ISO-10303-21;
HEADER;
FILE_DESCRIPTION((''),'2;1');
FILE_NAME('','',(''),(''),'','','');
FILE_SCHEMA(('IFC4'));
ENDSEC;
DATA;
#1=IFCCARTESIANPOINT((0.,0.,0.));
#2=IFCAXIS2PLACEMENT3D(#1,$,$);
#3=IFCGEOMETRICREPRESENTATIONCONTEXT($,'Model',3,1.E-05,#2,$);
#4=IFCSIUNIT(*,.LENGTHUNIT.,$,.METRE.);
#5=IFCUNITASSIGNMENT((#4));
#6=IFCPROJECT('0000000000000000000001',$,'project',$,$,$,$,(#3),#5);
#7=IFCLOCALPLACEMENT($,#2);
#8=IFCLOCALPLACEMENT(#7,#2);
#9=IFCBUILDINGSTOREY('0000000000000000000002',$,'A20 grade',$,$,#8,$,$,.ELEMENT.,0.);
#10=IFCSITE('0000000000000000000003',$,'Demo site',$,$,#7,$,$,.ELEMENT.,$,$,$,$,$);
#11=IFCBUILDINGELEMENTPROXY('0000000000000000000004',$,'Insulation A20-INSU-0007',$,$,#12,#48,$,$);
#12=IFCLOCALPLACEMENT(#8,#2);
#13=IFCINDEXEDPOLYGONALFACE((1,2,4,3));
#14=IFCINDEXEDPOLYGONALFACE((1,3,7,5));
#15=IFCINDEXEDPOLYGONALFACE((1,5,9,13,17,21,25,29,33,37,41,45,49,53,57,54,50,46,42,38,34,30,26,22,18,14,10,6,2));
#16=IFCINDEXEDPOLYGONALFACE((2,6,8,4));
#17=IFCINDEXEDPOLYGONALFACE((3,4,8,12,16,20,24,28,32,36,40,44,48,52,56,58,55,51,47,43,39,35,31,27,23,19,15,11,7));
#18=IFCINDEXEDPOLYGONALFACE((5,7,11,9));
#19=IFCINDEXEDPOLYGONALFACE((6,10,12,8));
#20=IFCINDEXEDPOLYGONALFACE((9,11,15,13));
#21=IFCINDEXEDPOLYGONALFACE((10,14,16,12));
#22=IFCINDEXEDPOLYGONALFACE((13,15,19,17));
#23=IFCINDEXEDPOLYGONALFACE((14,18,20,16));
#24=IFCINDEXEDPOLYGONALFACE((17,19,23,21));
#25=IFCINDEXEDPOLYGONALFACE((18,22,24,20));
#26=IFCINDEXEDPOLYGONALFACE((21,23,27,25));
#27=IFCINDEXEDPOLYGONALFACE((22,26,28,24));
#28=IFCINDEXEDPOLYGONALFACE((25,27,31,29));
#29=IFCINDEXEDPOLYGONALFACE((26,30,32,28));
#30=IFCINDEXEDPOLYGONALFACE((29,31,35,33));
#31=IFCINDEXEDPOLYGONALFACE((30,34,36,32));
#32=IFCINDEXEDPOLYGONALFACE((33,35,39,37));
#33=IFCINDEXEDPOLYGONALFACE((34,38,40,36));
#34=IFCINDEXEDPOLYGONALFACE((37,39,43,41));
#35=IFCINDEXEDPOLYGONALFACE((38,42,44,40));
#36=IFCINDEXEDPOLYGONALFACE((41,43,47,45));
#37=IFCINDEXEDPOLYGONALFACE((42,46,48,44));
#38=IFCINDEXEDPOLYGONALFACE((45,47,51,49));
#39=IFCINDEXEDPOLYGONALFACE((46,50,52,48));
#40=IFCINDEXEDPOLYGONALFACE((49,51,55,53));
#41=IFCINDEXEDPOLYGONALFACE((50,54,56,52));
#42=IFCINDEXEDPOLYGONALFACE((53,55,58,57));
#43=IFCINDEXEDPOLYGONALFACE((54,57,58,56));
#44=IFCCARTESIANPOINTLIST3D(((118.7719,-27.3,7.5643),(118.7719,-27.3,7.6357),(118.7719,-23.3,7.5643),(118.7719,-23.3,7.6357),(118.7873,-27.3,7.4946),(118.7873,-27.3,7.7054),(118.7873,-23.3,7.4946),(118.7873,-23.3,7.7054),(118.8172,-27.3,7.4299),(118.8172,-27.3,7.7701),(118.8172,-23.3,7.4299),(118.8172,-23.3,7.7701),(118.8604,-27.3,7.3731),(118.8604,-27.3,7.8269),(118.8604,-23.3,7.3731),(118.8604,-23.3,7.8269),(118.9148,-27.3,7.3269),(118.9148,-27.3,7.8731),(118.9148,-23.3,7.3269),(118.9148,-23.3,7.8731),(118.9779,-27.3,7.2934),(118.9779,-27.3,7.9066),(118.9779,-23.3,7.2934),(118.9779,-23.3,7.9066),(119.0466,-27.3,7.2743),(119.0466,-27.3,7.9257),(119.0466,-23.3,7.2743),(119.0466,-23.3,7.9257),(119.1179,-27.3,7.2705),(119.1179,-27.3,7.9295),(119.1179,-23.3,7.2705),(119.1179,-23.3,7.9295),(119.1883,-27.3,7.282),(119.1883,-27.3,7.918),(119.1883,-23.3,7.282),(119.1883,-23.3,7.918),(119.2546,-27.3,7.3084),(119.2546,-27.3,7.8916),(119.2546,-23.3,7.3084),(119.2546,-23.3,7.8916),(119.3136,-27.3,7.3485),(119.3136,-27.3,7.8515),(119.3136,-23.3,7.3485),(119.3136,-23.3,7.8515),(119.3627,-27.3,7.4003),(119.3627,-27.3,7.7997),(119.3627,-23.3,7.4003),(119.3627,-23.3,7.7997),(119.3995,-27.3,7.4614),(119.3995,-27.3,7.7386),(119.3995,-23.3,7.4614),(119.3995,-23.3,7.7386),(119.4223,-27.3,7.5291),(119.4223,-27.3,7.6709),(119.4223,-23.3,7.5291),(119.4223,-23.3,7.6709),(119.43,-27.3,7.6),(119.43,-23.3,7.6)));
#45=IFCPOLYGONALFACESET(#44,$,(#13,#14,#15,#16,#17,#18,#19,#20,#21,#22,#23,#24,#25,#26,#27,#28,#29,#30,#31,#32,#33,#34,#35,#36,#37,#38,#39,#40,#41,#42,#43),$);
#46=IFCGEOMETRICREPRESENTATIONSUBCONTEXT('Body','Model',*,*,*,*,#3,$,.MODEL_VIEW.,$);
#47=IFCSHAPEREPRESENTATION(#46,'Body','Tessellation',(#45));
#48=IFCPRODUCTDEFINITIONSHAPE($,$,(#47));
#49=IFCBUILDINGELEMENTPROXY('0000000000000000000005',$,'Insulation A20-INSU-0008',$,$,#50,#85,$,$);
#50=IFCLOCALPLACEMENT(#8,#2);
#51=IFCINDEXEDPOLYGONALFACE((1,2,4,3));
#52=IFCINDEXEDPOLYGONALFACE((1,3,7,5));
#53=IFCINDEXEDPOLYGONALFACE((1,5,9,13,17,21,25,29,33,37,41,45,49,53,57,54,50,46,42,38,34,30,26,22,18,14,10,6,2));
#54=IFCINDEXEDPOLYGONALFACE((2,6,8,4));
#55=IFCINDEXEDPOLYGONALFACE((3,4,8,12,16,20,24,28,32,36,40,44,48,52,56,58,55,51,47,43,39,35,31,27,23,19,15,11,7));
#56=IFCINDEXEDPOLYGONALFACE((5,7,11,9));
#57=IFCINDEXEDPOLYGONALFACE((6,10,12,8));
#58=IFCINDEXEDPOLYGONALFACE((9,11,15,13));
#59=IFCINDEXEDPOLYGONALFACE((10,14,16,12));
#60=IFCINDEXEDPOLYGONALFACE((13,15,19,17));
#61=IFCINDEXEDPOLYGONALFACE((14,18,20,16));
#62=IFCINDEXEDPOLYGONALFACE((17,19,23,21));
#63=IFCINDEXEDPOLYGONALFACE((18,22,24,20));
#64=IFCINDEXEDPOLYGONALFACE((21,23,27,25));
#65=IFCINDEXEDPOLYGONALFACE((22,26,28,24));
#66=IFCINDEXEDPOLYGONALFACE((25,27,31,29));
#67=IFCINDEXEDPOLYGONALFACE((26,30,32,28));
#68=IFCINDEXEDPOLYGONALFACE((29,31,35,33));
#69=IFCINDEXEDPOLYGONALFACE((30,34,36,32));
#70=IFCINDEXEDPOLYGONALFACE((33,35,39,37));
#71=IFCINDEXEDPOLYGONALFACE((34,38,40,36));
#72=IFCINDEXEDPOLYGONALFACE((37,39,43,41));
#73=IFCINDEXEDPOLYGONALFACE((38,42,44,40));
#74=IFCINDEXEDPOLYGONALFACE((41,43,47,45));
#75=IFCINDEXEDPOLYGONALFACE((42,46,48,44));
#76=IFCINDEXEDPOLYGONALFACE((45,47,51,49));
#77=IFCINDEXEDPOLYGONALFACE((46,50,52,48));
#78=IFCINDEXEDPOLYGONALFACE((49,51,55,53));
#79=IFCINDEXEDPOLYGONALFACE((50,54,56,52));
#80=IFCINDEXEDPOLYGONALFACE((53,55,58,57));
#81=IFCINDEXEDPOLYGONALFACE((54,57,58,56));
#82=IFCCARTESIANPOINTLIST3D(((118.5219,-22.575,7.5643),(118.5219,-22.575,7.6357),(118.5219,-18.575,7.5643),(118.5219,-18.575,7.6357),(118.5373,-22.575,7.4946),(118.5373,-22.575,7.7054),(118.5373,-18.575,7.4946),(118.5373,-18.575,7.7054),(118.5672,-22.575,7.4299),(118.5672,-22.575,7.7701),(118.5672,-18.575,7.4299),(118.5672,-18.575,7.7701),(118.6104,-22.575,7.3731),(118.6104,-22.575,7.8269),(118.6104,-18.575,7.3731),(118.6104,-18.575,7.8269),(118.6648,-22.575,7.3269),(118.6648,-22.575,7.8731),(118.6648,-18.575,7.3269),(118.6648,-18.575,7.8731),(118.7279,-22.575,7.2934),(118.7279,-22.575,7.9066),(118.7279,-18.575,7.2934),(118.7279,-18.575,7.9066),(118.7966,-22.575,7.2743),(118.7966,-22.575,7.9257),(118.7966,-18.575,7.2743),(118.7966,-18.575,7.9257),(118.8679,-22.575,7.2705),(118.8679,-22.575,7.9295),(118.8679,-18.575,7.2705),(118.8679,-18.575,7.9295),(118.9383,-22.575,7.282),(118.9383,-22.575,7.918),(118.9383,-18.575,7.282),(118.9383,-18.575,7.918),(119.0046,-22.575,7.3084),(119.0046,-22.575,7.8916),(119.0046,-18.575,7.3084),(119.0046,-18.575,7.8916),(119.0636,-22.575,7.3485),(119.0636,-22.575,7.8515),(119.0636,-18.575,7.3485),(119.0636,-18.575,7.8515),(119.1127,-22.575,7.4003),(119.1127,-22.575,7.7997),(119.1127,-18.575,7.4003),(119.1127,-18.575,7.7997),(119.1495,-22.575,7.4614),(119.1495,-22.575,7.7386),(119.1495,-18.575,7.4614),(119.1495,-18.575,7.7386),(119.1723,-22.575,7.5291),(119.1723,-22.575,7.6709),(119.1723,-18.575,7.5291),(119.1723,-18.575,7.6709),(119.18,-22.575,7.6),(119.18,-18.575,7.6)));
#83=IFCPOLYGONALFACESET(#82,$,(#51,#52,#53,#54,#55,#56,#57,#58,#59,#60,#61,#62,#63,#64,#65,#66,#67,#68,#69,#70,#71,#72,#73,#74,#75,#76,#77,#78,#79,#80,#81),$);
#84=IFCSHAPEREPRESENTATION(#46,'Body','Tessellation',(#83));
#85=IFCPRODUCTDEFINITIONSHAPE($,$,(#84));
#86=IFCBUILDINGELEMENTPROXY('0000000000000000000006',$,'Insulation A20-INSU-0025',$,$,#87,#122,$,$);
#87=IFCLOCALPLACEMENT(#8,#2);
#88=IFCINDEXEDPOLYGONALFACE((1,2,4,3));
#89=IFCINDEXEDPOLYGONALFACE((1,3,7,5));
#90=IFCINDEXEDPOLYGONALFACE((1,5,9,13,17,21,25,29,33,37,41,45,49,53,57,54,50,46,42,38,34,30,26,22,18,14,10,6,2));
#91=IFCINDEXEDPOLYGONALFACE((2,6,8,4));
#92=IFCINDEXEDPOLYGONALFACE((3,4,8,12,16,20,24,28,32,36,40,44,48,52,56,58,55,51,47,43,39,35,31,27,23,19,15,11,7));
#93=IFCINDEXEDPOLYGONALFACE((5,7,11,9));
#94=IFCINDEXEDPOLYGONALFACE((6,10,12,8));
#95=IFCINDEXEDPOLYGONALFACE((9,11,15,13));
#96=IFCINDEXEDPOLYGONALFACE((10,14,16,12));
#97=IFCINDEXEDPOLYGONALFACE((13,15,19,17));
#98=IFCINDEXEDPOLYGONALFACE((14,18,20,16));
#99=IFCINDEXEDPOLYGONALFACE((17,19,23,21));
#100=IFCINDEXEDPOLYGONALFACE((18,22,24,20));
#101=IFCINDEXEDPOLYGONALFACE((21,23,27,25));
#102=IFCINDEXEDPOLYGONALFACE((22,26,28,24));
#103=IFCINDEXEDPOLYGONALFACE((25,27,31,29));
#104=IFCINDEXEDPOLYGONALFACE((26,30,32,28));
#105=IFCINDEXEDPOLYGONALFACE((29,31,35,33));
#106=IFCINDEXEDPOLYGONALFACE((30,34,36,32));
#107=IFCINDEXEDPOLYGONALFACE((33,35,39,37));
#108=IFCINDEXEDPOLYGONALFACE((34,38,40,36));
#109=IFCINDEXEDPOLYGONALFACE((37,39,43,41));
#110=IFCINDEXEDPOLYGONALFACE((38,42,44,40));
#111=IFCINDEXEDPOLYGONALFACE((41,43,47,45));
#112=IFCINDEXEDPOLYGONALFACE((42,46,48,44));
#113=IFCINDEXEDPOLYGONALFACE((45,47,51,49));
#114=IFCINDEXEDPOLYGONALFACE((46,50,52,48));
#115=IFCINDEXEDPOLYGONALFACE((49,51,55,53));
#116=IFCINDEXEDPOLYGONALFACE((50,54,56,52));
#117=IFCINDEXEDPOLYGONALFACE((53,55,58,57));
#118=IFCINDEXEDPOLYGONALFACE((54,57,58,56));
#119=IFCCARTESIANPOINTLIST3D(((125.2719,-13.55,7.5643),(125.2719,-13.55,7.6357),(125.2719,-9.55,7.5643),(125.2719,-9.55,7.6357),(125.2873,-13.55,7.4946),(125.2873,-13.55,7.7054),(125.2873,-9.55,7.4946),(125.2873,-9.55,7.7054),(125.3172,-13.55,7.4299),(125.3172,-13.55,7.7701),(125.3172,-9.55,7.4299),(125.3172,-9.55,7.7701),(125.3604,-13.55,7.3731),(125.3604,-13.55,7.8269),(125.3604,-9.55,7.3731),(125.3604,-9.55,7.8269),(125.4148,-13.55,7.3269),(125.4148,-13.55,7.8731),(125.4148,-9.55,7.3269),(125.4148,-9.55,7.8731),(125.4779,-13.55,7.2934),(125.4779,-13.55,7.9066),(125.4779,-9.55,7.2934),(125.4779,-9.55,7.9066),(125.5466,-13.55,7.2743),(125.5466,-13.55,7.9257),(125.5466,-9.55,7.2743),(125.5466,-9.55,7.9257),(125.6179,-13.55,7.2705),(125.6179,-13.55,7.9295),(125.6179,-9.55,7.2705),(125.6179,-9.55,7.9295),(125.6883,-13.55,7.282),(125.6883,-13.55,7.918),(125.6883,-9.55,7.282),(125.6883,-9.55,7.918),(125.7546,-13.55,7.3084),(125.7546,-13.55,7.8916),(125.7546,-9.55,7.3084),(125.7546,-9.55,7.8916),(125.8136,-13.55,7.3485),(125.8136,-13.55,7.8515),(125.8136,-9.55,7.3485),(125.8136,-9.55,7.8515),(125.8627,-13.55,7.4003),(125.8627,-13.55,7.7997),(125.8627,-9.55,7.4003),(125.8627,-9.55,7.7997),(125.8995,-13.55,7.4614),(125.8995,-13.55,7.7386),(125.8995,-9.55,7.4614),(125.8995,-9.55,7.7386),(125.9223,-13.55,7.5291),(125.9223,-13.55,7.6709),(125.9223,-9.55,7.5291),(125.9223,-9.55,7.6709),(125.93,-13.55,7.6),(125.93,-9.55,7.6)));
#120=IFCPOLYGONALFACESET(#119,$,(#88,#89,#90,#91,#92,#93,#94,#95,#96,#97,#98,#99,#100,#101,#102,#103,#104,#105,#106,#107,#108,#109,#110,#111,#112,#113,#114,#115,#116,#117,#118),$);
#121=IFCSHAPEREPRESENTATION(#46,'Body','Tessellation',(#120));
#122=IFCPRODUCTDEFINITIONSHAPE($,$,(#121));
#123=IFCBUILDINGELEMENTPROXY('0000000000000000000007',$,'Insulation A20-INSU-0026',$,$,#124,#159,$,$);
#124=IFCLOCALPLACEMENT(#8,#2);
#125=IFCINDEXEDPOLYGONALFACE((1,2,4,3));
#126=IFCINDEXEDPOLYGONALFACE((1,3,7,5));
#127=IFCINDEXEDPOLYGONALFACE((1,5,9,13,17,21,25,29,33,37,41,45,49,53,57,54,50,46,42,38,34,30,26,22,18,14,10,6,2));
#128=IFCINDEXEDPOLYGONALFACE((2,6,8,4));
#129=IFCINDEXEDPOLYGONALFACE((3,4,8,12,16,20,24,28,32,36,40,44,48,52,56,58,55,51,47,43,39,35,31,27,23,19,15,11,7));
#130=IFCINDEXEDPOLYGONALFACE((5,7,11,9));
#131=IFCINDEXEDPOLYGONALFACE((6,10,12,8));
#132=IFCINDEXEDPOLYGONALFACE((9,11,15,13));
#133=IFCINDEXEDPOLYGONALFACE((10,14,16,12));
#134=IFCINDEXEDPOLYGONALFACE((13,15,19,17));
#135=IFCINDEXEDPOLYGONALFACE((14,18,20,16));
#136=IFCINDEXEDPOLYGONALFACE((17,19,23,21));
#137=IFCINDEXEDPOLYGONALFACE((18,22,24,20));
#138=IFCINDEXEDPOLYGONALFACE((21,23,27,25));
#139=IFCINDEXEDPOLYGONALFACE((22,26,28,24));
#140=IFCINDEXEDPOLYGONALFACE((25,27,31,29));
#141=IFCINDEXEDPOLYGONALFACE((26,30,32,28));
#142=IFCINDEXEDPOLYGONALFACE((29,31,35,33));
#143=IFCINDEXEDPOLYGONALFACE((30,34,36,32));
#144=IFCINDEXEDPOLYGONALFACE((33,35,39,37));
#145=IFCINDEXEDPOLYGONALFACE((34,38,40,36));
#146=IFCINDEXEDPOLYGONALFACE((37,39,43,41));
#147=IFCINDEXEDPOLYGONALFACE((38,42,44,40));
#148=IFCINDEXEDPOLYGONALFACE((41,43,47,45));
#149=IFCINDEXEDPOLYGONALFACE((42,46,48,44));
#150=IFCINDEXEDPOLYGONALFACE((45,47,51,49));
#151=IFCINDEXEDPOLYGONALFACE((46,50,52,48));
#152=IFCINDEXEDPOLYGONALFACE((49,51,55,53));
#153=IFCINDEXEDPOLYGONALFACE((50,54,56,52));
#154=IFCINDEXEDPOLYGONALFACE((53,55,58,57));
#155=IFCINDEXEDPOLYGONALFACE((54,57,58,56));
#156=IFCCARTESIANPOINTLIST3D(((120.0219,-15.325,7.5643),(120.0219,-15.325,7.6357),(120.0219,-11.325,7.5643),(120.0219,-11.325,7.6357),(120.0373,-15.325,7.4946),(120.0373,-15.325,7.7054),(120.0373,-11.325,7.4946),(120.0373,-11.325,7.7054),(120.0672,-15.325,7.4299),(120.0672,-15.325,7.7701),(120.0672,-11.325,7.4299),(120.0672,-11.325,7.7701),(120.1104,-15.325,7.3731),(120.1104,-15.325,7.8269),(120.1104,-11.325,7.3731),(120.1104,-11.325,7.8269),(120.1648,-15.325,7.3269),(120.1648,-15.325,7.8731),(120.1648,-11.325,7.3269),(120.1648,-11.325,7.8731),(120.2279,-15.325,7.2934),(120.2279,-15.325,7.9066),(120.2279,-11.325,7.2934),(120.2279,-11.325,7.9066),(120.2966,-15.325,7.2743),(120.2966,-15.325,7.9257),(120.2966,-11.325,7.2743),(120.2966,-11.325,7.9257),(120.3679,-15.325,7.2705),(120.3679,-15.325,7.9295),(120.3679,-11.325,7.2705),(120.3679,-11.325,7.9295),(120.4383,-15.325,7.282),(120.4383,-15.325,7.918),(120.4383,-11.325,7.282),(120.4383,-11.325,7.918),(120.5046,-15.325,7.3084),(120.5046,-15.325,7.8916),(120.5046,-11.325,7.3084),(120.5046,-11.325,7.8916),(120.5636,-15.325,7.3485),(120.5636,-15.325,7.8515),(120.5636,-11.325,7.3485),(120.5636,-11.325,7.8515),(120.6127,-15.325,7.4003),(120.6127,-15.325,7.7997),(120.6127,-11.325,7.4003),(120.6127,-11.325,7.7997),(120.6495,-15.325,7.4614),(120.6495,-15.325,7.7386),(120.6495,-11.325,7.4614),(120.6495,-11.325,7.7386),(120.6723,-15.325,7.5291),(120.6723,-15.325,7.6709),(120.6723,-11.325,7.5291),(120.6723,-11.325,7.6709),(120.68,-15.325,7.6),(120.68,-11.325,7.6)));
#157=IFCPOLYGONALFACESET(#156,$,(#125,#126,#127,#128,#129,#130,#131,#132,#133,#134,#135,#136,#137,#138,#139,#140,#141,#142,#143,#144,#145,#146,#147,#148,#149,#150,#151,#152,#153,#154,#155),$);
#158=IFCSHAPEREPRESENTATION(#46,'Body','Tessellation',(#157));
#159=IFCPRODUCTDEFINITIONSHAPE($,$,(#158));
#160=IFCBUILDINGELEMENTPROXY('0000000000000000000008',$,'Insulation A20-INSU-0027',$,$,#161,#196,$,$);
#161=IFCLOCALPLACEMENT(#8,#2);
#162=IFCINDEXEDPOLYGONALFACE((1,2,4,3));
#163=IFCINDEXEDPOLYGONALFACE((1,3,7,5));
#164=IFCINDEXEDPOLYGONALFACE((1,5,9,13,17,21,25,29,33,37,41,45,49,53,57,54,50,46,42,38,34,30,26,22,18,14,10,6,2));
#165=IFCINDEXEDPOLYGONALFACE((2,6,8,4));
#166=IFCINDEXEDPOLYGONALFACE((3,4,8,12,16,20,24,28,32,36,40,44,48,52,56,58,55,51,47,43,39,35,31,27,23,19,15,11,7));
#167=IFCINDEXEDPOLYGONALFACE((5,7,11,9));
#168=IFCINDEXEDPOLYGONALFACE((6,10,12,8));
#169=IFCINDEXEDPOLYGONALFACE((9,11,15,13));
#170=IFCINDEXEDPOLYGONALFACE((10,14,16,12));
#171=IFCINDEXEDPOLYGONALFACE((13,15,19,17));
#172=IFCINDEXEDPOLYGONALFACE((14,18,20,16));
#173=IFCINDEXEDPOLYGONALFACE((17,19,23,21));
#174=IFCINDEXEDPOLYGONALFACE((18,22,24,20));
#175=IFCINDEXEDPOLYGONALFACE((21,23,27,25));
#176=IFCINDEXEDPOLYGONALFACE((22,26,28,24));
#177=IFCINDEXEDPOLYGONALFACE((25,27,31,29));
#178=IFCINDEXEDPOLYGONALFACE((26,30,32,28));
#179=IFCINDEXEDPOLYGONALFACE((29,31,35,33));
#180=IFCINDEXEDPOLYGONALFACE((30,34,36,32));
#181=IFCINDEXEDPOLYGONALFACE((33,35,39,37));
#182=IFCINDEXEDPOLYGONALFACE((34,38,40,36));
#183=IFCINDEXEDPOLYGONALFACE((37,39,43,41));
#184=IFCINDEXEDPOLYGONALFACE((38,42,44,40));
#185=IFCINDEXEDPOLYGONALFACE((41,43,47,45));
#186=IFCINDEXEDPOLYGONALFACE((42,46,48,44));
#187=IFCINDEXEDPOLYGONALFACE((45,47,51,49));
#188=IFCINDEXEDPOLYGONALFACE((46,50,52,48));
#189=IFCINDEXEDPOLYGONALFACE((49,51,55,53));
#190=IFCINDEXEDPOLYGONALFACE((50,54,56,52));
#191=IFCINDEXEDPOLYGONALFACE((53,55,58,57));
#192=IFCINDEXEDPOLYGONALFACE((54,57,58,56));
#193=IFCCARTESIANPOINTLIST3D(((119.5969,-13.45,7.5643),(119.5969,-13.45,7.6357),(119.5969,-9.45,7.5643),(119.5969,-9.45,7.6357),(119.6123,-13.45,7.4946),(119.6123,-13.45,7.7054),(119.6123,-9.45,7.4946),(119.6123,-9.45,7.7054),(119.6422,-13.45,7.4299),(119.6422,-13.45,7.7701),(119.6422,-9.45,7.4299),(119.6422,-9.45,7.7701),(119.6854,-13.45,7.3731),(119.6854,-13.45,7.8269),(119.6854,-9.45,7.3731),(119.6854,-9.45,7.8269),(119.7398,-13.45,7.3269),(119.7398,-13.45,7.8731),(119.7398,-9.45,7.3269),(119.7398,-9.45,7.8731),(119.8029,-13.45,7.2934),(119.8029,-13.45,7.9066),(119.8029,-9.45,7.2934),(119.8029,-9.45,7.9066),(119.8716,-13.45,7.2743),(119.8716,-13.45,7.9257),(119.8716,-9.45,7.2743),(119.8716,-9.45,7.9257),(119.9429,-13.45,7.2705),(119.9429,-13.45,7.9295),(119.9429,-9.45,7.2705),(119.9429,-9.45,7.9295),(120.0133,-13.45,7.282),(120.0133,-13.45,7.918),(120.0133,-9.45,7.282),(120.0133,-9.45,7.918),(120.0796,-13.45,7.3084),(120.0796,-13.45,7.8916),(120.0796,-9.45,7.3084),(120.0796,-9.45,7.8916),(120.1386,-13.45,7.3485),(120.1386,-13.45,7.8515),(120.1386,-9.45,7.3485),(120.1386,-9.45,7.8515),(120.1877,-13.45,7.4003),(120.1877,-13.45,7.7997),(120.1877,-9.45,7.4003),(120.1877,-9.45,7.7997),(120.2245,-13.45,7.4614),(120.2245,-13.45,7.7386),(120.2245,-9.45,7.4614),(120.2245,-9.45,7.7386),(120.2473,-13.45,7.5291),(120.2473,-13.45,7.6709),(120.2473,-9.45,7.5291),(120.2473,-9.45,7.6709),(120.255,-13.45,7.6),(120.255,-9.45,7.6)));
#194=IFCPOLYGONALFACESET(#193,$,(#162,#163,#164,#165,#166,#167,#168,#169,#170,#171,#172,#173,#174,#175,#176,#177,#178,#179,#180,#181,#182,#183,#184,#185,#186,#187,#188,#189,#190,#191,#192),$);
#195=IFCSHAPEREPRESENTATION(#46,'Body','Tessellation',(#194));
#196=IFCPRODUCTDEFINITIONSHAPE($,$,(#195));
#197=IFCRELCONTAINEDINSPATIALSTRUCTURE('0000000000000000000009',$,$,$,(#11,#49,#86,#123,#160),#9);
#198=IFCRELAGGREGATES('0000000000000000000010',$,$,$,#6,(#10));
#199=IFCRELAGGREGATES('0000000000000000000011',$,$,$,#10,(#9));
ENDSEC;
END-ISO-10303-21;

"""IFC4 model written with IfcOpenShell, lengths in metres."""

from ifc_helpers import new_model, si_unit, frame, origin, place, context, subcontext, project, spatial, circle, extrude, element, save


model = new_model("IFC4")

# Units and contexts
model_context = context("Model", 3, precision=1e-05, world=origin())
body_context = subcontext(model_context, "Body", "Model", "MODEL_VIEW")
ifc_project = project(units=[si_unit("LENGTHUNIT", "METRE")], contexts=[model_context])

# Site, storey
site_placement = place(None, origin())
site = spatial("IfcSite", under=ifc_project, at=site_placement, Name="Demo site", CompositionType="ELEMENT")
storey_placement = place(site_placement, origin())
storey = spatial("IfcBuildingStorey", under=site, at=storey_placement, Name="A20 grade", CompositionType="ELEMENT", Elevation=0.0)

# Building element proxies
for number, where, name in (
    (1, (119.1, -27.3, 7.6), "Insulation A20-INSU-0007"),
    (2, (118.85, -22.575, 7.6), "Insulation A20-INSU-0008"),
    (3, (125.6, -13.55, 7.6), "Insulation A20-INSU-0025"),
    (4, (120.35, -15.325, 7.6), "Insulation A20-INSU-0026"),
    (5, (119.925, -13.45, 7.6), "Insulation A20-INSU-0027"),
):
    element("IfcBuildingElementProxy", number, at=place(storey_placement, frame(where)), inside=storey, Name=name, context=body_context, shape_type="SweptSolid", body=[
        extrude(circle(Radius=0.33), frame((0.0, 0.0, 0.0), z_axis=(0.0, 1.0, 0.0), x_axis=(1.0, 0.0, 0.0)), (0.0, 0.0, 1.0), 4.0),
    ])

save(model, "model.ifc")
